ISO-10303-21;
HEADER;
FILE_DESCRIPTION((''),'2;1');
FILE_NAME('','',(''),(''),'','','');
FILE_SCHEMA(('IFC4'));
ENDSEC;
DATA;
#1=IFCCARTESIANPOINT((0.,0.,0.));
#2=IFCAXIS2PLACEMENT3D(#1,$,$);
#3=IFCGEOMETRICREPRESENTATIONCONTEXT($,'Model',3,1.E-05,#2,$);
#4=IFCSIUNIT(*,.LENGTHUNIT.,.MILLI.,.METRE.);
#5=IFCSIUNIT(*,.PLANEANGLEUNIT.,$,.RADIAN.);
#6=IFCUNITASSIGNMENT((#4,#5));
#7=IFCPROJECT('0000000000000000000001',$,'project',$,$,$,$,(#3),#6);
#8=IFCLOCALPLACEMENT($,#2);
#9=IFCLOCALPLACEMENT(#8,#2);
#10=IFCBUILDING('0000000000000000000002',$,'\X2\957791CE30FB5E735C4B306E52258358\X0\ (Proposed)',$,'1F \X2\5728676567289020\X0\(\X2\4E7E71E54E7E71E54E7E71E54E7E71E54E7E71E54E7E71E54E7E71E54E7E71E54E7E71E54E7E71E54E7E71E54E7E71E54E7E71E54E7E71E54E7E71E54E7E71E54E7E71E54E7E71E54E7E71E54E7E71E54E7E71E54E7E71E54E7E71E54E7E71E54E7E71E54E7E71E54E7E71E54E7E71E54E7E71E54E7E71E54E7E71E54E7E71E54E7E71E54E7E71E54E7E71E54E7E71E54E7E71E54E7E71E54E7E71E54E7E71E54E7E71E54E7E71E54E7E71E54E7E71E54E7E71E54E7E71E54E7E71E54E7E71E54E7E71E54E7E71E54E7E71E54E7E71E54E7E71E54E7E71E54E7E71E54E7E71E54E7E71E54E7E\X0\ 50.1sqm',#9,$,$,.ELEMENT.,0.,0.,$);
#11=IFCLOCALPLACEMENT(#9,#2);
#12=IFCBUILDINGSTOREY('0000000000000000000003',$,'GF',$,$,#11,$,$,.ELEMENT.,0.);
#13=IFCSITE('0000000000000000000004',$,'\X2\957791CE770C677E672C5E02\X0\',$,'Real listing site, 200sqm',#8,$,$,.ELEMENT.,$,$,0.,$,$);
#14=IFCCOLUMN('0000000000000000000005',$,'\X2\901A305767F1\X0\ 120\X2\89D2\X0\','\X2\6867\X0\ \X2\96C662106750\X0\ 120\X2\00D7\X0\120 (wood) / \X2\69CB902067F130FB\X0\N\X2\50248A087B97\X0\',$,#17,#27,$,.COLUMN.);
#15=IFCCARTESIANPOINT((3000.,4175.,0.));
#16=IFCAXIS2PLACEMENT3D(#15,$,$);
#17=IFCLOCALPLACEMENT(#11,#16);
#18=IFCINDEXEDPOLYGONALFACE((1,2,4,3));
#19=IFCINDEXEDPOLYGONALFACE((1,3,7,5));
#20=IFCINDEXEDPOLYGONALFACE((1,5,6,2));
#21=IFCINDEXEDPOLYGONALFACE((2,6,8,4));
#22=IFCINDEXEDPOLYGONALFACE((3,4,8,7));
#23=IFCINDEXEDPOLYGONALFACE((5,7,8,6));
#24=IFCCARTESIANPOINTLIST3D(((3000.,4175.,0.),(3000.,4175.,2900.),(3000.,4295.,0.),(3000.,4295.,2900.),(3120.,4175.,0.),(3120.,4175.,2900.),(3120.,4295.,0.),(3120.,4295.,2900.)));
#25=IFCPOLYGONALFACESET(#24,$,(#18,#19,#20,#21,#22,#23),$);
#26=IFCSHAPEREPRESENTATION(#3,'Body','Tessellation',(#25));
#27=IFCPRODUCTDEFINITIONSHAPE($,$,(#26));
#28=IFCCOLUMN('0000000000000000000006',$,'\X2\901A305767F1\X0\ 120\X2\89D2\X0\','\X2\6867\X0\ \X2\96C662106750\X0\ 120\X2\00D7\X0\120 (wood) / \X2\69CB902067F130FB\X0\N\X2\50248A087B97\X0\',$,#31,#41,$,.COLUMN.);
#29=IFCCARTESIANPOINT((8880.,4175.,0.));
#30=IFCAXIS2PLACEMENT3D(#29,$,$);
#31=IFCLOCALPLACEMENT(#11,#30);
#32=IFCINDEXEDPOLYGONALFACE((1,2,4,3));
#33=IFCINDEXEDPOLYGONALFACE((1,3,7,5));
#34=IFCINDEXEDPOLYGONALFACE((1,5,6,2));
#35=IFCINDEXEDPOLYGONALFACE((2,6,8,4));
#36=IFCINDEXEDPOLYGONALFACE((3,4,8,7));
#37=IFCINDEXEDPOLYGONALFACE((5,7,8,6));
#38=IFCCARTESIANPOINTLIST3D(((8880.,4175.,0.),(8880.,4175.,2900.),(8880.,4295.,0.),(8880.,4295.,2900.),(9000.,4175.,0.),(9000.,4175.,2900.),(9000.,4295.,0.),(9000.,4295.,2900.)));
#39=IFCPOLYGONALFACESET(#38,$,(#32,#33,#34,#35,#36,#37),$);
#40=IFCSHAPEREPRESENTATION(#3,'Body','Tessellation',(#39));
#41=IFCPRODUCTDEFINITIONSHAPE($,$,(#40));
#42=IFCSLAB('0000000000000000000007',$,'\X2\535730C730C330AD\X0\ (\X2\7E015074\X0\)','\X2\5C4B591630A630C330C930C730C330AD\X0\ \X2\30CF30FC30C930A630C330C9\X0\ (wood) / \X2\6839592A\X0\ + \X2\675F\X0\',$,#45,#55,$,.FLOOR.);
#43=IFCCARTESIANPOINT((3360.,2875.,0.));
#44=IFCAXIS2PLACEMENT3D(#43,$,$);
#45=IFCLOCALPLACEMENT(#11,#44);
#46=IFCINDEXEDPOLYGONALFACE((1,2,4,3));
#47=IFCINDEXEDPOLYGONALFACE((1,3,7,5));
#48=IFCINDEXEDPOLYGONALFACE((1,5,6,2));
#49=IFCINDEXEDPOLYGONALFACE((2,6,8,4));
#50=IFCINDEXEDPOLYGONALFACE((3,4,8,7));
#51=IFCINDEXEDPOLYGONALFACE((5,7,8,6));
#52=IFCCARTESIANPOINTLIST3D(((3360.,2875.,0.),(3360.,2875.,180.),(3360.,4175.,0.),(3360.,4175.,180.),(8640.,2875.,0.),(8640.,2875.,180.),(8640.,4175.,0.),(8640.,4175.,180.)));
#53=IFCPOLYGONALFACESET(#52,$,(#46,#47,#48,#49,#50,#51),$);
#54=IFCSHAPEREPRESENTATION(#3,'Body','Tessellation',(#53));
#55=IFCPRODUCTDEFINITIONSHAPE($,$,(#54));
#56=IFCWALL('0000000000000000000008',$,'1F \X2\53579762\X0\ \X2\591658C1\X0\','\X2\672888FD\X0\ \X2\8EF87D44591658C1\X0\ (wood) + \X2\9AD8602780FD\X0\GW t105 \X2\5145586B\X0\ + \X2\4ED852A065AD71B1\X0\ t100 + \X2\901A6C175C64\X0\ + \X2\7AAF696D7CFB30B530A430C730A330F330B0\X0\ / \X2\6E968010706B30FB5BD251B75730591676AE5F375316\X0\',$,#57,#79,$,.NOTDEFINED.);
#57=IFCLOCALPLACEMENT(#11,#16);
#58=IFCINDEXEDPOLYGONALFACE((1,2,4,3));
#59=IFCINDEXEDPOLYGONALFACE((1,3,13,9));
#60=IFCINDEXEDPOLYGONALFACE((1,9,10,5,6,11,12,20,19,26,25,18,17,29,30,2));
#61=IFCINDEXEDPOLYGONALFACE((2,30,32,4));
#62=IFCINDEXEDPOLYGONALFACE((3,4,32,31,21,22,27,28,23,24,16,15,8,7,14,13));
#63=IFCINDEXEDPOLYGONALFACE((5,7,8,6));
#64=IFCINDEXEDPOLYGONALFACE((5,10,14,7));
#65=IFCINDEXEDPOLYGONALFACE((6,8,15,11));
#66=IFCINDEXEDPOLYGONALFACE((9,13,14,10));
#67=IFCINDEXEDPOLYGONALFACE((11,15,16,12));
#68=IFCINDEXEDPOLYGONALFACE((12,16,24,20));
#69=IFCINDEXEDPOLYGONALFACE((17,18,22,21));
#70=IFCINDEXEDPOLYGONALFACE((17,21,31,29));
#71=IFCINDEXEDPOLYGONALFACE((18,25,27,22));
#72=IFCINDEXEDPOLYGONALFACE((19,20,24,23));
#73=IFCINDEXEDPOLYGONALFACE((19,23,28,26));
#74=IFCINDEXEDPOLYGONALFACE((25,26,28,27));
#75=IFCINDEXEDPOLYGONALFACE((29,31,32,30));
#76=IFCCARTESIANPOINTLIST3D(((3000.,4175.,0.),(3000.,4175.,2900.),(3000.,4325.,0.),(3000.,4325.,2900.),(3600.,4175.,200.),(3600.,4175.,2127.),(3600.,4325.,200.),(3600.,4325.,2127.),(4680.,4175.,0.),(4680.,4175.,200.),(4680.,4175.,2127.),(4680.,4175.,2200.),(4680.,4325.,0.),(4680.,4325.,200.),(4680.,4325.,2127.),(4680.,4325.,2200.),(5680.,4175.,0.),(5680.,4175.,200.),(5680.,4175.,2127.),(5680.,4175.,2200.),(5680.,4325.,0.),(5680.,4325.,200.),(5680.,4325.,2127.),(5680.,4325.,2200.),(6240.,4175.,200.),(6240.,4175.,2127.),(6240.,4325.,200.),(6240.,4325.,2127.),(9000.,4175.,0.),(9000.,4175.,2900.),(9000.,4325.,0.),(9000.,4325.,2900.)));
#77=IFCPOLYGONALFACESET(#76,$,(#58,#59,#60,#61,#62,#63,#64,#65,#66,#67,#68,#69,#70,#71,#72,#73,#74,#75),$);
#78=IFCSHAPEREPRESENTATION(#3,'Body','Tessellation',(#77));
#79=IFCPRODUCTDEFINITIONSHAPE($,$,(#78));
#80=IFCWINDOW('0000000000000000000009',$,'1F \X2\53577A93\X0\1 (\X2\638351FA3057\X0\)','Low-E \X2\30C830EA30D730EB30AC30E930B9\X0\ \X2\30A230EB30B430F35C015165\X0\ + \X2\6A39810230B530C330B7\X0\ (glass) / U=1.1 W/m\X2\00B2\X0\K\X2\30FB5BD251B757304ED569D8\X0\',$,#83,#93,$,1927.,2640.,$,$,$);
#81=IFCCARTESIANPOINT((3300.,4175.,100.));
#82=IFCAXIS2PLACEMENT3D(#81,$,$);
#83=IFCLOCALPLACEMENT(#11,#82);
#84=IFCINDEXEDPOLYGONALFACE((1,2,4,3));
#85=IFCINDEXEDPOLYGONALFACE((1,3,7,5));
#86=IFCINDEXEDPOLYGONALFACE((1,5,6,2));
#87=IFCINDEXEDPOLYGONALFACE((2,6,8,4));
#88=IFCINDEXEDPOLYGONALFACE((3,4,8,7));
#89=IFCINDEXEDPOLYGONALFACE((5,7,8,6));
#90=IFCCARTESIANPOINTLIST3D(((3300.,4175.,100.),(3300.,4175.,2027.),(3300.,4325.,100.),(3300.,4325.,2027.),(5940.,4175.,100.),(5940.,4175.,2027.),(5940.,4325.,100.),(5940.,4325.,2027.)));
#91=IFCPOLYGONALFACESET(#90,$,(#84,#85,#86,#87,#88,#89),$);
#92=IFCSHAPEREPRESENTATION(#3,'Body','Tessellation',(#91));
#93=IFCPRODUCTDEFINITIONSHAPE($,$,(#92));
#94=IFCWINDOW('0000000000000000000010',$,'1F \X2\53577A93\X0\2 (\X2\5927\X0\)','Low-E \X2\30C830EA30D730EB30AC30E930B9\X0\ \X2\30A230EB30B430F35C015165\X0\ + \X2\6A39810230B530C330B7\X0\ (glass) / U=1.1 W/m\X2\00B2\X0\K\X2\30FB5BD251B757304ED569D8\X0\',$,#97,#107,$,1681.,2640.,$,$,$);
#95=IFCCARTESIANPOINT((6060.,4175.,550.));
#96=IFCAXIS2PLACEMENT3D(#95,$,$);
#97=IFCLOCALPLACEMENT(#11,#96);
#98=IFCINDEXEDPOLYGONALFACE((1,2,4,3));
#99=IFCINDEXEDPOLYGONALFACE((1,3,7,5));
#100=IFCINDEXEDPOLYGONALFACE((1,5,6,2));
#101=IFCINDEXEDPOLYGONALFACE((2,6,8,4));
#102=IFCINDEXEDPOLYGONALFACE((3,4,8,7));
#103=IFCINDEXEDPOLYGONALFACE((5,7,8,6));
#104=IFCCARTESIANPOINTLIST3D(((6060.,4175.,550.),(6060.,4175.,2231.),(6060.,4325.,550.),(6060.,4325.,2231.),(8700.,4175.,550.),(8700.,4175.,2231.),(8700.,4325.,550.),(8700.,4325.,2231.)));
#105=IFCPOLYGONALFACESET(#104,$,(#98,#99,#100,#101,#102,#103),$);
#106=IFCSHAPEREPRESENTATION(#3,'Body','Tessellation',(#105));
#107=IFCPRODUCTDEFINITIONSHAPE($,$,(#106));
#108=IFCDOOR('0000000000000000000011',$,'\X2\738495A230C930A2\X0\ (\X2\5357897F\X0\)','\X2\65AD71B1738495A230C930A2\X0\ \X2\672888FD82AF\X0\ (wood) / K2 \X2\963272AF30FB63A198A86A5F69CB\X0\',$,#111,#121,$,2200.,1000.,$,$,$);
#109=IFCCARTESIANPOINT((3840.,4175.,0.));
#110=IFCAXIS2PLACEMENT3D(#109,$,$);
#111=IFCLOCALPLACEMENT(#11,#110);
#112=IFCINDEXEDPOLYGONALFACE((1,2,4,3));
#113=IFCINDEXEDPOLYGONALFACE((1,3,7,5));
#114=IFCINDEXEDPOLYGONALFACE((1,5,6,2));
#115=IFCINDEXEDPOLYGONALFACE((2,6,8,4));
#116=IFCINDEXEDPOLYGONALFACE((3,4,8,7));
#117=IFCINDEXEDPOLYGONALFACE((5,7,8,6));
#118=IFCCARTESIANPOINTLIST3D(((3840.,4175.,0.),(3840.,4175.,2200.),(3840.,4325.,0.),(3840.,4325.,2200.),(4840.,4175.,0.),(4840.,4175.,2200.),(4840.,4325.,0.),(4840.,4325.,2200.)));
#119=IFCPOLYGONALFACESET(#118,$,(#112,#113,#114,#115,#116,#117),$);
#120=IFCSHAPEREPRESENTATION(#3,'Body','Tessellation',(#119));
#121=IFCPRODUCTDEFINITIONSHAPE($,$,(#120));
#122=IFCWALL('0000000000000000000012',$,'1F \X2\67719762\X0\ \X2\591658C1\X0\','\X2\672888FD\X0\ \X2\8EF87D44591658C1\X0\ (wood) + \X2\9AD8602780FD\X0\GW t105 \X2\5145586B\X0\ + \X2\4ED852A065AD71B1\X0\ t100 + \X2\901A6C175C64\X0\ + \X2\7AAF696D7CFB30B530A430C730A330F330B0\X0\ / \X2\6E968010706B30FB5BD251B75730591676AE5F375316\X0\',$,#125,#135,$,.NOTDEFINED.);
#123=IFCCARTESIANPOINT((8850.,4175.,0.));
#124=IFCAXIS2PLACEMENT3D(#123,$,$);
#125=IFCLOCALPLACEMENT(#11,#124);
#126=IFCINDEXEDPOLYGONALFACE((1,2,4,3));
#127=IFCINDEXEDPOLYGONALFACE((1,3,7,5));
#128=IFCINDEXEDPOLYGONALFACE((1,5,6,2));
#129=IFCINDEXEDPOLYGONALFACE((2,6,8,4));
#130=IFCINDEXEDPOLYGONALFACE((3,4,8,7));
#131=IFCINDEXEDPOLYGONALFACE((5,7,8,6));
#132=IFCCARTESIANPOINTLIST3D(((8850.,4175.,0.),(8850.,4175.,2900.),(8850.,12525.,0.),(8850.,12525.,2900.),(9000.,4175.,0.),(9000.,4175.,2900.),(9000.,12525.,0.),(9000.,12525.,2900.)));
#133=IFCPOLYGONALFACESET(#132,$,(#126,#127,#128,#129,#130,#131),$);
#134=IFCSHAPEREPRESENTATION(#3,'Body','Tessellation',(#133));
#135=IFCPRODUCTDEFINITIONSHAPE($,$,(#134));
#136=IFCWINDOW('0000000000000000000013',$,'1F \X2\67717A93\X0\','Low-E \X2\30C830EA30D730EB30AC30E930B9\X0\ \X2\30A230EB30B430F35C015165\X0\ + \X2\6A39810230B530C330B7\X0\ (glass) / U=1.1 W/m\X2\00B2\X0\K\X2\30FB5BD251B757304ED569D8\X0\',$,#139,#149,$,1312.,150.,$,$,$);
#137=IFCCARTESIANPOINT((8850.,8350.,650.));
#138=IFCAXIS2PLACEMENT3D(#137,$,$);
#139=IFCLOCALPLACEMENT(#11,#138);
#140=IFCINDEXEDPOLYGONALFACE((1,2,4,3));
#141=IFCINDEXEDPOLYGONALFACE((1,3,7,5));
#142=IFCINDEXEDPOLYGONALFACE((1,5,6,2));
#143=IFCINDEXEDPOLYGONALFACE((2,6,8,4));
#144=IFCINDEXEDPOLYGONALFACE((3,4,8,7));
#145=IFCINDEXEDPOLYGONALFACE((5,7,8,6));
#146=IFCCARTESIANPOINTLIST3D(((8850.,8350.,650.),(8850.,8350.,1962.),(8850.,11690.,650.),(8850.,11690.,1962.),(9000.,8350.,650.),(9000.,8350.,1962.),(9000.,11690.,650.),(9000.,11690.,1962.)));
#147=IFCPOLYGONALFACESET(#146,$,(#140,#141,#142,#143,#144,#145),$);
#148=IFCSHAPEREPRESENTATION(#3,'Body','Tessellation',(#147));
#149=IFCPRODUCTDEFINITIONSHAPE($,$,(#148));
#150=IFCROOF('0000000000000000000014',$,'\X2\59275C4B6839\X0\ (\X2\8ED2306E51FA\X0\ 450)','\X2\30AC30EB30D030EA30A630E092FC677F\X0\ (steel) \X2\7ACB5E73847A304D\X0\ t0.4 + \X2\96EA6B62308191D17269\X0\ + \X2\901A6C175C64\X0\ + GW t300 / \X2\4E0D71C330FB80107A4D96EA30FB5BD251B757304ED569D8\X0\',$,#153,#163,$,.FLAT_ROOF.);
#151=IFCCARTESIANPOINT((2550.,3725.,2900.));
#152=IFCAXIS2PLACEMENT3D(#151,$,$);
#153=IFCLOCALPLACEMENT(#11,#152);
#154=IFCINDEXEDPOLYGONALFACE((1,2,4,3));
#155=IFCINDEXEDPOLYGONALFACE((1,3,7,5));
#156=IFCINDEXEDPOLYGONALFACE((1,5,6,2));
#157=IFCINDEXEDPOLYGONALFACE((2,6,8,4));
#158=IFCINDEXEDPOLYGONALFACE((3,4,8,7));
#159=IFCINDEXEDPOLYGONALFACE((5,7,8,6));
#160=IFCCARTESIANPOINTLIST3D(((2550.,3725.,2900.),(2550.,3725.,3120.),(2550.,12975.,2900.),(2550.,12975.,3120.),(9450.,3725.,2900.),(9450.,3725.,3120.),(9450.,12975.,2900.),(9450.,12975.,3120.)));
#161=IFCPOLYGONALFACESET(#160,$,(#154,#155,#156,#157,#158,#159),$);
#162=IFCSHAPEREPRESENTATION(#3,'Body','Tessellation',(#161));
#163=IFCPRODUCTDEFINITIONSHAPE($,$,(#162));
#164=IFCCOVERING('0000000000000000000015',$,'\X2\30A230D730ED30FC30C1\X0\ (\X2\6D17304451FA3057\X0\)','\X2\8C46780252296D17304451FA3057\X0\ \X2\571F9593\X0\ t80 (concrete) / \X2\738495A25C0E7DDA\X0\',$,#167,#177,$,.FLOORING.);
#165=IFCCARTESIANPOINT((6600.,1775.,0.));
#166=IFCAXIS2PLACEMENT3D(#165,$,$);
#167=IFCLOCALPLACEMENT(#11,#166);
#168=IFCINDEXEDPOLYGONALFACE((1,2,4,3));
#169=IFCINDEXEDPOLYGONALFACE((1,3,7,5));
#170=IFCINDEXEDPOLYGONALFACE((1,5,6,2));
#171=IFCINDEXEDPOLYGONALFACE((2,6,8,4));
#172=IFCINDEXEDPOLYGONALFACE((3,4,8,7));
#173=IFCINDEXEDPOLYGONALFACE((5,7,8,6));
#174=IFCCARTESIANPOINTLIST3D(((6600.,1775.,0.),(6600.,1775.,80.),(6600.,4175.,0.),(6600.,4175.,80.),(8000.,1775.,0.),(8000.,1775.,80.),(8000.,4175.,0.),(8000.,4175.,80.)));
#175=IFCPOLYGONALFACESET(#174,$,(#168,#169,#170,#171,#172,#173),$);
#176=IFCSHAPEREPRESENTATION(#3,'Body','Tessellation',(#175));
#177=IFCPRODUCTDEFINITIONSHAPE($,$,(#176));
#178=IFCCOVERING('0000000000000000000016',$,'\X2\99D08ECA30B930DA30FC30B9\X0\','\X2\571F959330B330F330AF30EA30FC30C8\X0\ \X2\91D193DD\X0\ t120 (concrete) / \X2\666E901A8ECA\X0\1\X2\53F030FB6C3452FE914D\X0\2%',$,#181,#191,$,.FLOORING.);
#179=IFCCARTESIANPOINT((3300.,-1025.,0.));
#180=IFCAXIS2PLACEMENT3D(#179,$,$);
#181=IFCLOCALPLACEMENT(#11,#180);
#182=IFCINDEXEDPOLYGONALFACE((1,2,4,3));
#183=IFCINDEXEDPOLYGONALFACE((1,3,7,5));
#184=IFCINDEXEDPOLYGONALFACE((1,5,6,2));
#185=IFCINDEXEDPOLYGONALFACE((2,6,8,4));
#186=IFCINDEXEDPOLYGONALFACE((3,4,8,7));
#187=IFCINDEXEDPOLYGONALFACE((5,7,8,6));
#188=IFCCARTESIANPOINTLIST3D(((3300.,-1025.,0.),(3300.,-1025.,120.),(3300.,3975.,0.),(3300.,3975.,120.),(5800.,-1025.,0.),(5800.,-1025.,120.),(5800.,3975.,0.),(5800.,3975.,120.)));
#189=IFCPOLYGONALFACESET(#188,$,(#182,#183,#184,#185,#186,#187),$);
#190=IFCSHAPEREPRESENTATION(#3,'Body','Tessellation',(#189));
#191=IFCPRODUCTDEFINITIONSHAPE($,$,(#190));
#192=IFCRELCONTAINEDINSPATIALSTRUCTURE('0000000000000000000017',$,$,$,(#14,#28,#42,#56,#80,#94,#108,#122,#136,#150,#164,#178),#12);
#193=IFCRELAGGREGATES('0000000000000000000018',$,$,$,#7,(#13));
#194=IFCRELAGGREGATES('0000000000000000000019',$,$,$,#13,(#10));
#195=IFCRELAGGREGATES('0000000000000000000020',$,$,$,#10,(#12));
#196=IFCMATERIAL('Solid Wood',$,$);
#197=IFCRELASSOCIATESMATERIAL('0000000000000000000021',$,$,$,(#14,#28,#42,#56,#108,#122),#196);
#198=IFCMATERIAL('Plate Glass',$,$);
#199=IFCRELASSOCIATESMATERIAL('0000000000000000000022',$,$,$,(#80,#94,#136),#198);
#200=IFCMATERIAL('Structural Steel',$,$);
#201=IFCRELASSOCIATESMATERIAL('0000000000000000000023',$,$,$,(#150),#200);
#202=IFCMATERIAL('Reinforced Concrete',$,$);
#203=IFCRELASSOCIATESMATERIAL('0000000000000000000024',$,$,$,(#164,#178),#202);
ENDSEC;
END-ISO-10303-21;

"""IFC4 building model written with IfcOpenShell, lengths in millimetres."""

from ifc_helpers import new_model, si_unit, frame, frame_2d, origin, place, context, project, spatial, rectangle, extrude, material, element, fill, save


model = new_model("IFC4")

# Units and contexts
model_context = context("Model", 3, precision=1e-05, world=origin())
ifc_project = project(units=[si_unit("LENGTHUNIT", "METRE", prefix="MILLI"), si_unit("PLANEANGLEUNIT", "RADIAN")], contexts=[model_context])

# Site, building, storey
site_placement = place(None, origin())
site = spatial("IfcSite", under=ifc_project, at=site_placement, Name="長野県松本市", ObjectType="Real listing site, 200sqm", CompositionType="ELEMENT", RefElevation=0.0)
building_placement = place(site_placement, origin())
building = spatial("IfcBuilding", under=site, at=building_placement, Name="長野・平屋の別荘 (Proposed)", ObjectType="1F 在来木造(乾燥乾燥乾燥乾燥乾燥乾燥乾燥乾燥乾燥乾燥乾燥乾燥乾燥乾燥乾燥乾燥乾燥乾燥乾燥乾燥乾燥乾燥乾燥乾燥乾燥乾燥乾燥乾燥乾燥乾燥乾燥乾燥乾燥乾燥乾燥乾燥乾燥乾燥乾燥乾燥乾燥乾燥乾燥乾燥乾燥乾燥乾燥乾燥乾燥乾燥乾燥乾燥乾燥乾燥乾燥乾燥乾燥乾 50.1sqm", CompositionType="ELEMENT", ElevationOfRefHeight=0.0, ElevationOfTerrain=0.0)
storey_placement = place(building_placement, origin())
storey = spatial("IfcBuildingStorey", under=building, at=storey_placement, Name="GF", CompositionType="ELEMENT", Elevation=0.0)

# Columns
ifc_material_1 = material(Name="Solid Wood")
column_1_placement = place(storey_placement, frame((3000.0, 4175.0, 0.0)))
element("IfcColumn", 1, at=column_1_placement, inside=storey, material=ifc_material_1, Name="通し柱 120角", Description="桧 集成材 120×120 (wood) / 構造柱・N値計算", PredefinedType="COLUMN", context=model_context, shape_type="SweptSolid", body=[
    extrude(rectangle(XDim=120.0, YDim=120.0, at=frame_2d((60.0, 60.0))), frame((3000.0, 4175.0, 0.0)), (0.0, 0.0, 1.0), 2900.0),
])
column_2_placement = place(storey_placement, frame((8880.0, 4175.0, 0.0)))
element("IfcColumn", 2, at=column_2_placement, inside=storey, material=ifc_material_1, Name="通し柱 120角", Description="桧 集成材 120×120 (wood) / 構造柱・N値計算", PredefinedType="COLUMN", context=model_context, shape_type="SweptSolid", body=[
    extrude(rectangle(XDim=120.0, YDim=120.0, at=frame_2d((60.0, 60.0))), frame((8880.0, 4175.0, 0.0)), (0.0, 0.0, 1.0), 2900.0),
])

# Slab
ifc_material_2 = material(Name="Reinforced Concrete")
slab_1_placement = place(storey_placement, frame((3360.0, 2875.0, 0.0)))
element("IfcSlab", 3, at=slab_1_placement, inside=storey, material=ifc_material_1, Name="南デッキ (縁側)", Description="屋外ウッドデッキ ハードウッド (wood) / 根太 + 束", PredefinedType="FLOOR", context=model_context, shape_type="SweptSolid", body=[
    extrude(rectangle(XDim=5280.0, YDim=1300.0, at=frame_2d((2640.0, 650.0))), frame((3360.0, 2875.0, 0.0)), (0.0, 0.0, 1.0), 180.0),
])

# Wall, openings, windows, door
wall_1_placement = place(storey_placement, frame((3000.0, 4175.0, 0.0)))
wall_1 = element("IfcWall", 4, at=wall_1_placement, inside=storey, material=ifc_material_1, Name="1F 南面 外壁", Description="木製 軸組外壁 (wood) + 高性能GW t105 充填 + 付加断熱 t100 + 通気層 + 窯業系サイディング / 準耐火・寒冷地外皮強化", PredefinedType="NOTDEFINED", context=model_context, shape_type="SweptSolid", body=[
    extrude(rectangle(XDim=6000.0, YDim=150.0, at=frame_2d((3000.0, 75.0))), frame((3000.0, 4175.0, 0.0)), (0.0, 0.0, 1.0), 2900.0),
])
opening_1_placement = place(storey_placement, frame((3300.0, 4175.0, 100.0)))
opening_1 = element("IfcOpeningElement", 5, at=opening_1_placement, cuts=wall_1, PredefinedType="NOTDEFINED", context=model_context, shape_type="SweptSolid", body=[
    extrude(rectangle(XDim=2640.0, YDim=150.0, at=frame_2d((1320.0, 75.0))), frame((3300.0, 4175.0, 100.0)), (0.0, 0.0, 1.0), 1927.0),
])
opening_2_placement = place(storey_placement, frame((6060.0, 4175.0, 550.0)))
opening_2 = element("IfcOpeningElement", 6, at=opening_2_placement, cuts=wall_1, PredefinedType="NOTDEFINED", context=model_context, shape_type="SweptSolid", body=[
    extrude(rectangle(XDim=2640.0, YDim=150.0, at=frame_2d((1320.0, 75.0))), frame((6060.0, 4175.0, 550.0)), (0.0, 0.0, 1.0), 1681.0),
])
opening_3_placement = place(storey_placement, frame((3840.0, 4175.0, 0.0)))
opening_3 = element("IfcOpeningElement", 7, at=opening_3_placement, cuts=wall_1, PredefinedType="NOTDEFINED", context=model_context, shape_type="SweptSolid", body=[
    extrude(rectangle(XDim=1000.0, YDim=150.0, at=frame_2d((500.0, 75.0))), frame((3840.0, 4175.0, 0.0)), (0.0, 0.0, 1.0), 2200.0),
])
ifc_material_3 = material(Name="Plate Glass")
window_1_placement = place(storey_placement, frame((3300.0, 4175.0, 100.0)))
window_1 = element("IfcWindow", 8, at=window_1_placement, inside=storey, material=ifc_material_3, Name="1F 南窓1 (掃出し)", Description="Low-E トリプルガラス アルゴン封入 + 樹脂サッシ (glass) / U=1.1 W/m²K・寒冷地仕様", OverallHeight=1927.0, OverallWidth=2640.0, context=model_context, shape_type="SweptSolid", body=[
    extrude(rectangle(XDim=2640.0, YDim=150.0, at=frame_2d((1320.0, 75.0))), frame((3300.0, 4175.0, 100.0)), (0.0, 0.0, 1.0), 1927.0),
])
fill(opening_1, window_1)
window_2_placement = place(storey_placement, frame((6060.0, 4175.0, 550.0)))
window_2 = element("IfcWindow", 9, at=window_2_placement, inside=storey, material=ifc_material_3, Name="1F 南窓2 (大)", Description="Low-E トリプルガラス アルゴン封入 + 樹脂サッシ (glass) / U=1.1 W/m²K・寒冷地仕様", OverallHeight=1681.0, OverallWidth=2640.0, context=model_context, shape_type="SweptSolid", body=[
    extrude(rectangle(XDim=2640.0, YDim=150.0, at=frame_2d((1320.0, 75.0))), frame((6060.0, 4175.0, 550.0)), (0.0, 0.0, 1.0), 1681.0),
])
fill(opening_2, window_2)
door_placement = place(storey_placement, frame((3840.0, 4175.0, 0.0)))
door = element("IfcDoor", 10, at=door_placement, inside=storey, material=ifc_material_1, Name="玄関ドア (南西)", Description="断熱玄関ドア 木製芯 (wood) / K2 防犯・採風機構", OverallHeight=2200.0, OverallWidth=1000.0, context=model_context, shape_type="SweptSolid", body=[
    extrude(rectangle(XDim=1000.0, YDim=150.0, at=frame_2d((500.0, 75.0))), frame((3840.0, 4175.0, 0.0)), (0.0, 0.0, 1.0), 2200.0),
])
fill(opening_3, door)

# Wall, opening, window
wall_2_placement = place(storey_placement, frame((8850.0, 4175.0, 0.0)))
wall_2 = element("IfcWall", 11, at=wall_2_placement, inside=storey, material=ifc_material_1, Name="1F 東面 外壁", Description="木製 軸組外壁 (wood) + 高性能GW t105 充填 + 付加断熱 t100 + 通気層 + 窯業系サイディング / 準耐火・寒冷地外皮強化", PredefinedType="NOTDEFINED", context=model_context, shape_type="SweptSolid", body=[
    extrude(rectangle(XDim=150.0, YDim=8350.0, at=frame_2d((75.0, 4175.0))), frame((8850.0, 4175.0, 0.0)), (0.0, 0.0, 1.0), 2900.0),
])
opening_4_placement = place(storey_placement, frame((8850.0, 8350.0, 650.0)))
opening_4 = element("IfcOpeningElement", 12, at=opening_4_placement, cuts=wall_2, PredefinedType="NOTDEFINED", context=model_context, shape_type="SweptSolid", body=[
    extrude(rectangle(XDim=150.0, YDim=3340.0, at=frame_2d((75.0, 1670.0))), frame((8850.0, 8350.0, 650.0)), (0.0, 0.0, 1.0), 1312.0),
])
window_3_placement = place(storey_placement, frame((8850.0, 8350.0, 650.0)))
window_3 = element("IfcWindow", 13, at=window_3_placement, inside=storey, material=ifc_material_3, Name="1F 東窓", Description="Low-E トリプルガラス アルゴン封入 + 樹脂サッシ (glass) / U=1.1 W/m²K・寒冷地仕様", OverallHeight=1312.0, OverallWidth=150.0, context=model_context, shape_type="SweptSolid", body=[
    extrude(rectangle(XDim=150.0, YDim=3340.0, at=frame_2d((75.0, 1670.0))), frame((8850.0, 8350.0, 650.0)), (0.0, 0.0, 1.0), 1312.0),
])
fill(opening_4, window_3)

# Roof
ifc_material_4 = material(Name="Structural Steel")
roof_placement = place(storey_placement, frame((2550.0, 3725.0, 2900.0)))
element("IfcRoof", 14, at=roof_placement, inside=storey, material=ifc_material_4, Name="大屋根 (軒の出 450)", Description="ガルバリウム鋼板 (steel) 立平葺き t0.4 + 雪止め金物 + 通気層 + GW t300 / 不燃・耐積雪・寒冷地仕様", PredefinedType="FLAT_ROOF", context=model_context, shape_type="SweptSolid", body=[
    extrude(rectangle(XDim=6900.0, YDim=9250.0, at=frame_2d((3450.0, 4625.0))), frame((2550.0, 3725.0, 2900.0)), (0.0, 0.0, 1.0), 220.0),
])

# Coverings
covering_1_placement = place(storey_placement, frame((6600.0, 1775.0, 0.0)))
element("IfcCovering", 15, at=covering_1_placement, inside=storey, material=ifc_material_2, Name="アプローチ (洗い出し)", Description="豆砂利洗い出し 土間 t80 (concrete) / 玄関導線", PredefinedType="FLOORING", context=model_context, shape_type="SweptSolid", body=[
    extrude(rectangle(XDim=1400.0, YDim=2400.0, at=frame_2d((700.0, 1200.0))), frame((6600.0, 1775.0, 0.0)), (0.0, 0.0, 1.0), 80.0),
])
covering_2_placement = place(storey_placement, frame((3300.0, -1025.0, 0.0)))
element("IfcCovering", 16, at=covering_2_placement, inside=storey, material=ifc_material_2, Name="駐車スペース", Description="土間コンクリート 金鏝 t120 (concrete) / 普通車1台・水勾配2%", PredefinedType="FLOORING", context=model_context, shape_type="SweptSolid", body=[
    extrude(rectangle(XDim=2500.0, YDim=5000.0, at=frame_2d((1250.0, 2500.0))), frame((3300.0, -1025.0, 0.0)), (0.0, 0.0, 1.0), 120.0),
])

save(model, "model.ifc")
